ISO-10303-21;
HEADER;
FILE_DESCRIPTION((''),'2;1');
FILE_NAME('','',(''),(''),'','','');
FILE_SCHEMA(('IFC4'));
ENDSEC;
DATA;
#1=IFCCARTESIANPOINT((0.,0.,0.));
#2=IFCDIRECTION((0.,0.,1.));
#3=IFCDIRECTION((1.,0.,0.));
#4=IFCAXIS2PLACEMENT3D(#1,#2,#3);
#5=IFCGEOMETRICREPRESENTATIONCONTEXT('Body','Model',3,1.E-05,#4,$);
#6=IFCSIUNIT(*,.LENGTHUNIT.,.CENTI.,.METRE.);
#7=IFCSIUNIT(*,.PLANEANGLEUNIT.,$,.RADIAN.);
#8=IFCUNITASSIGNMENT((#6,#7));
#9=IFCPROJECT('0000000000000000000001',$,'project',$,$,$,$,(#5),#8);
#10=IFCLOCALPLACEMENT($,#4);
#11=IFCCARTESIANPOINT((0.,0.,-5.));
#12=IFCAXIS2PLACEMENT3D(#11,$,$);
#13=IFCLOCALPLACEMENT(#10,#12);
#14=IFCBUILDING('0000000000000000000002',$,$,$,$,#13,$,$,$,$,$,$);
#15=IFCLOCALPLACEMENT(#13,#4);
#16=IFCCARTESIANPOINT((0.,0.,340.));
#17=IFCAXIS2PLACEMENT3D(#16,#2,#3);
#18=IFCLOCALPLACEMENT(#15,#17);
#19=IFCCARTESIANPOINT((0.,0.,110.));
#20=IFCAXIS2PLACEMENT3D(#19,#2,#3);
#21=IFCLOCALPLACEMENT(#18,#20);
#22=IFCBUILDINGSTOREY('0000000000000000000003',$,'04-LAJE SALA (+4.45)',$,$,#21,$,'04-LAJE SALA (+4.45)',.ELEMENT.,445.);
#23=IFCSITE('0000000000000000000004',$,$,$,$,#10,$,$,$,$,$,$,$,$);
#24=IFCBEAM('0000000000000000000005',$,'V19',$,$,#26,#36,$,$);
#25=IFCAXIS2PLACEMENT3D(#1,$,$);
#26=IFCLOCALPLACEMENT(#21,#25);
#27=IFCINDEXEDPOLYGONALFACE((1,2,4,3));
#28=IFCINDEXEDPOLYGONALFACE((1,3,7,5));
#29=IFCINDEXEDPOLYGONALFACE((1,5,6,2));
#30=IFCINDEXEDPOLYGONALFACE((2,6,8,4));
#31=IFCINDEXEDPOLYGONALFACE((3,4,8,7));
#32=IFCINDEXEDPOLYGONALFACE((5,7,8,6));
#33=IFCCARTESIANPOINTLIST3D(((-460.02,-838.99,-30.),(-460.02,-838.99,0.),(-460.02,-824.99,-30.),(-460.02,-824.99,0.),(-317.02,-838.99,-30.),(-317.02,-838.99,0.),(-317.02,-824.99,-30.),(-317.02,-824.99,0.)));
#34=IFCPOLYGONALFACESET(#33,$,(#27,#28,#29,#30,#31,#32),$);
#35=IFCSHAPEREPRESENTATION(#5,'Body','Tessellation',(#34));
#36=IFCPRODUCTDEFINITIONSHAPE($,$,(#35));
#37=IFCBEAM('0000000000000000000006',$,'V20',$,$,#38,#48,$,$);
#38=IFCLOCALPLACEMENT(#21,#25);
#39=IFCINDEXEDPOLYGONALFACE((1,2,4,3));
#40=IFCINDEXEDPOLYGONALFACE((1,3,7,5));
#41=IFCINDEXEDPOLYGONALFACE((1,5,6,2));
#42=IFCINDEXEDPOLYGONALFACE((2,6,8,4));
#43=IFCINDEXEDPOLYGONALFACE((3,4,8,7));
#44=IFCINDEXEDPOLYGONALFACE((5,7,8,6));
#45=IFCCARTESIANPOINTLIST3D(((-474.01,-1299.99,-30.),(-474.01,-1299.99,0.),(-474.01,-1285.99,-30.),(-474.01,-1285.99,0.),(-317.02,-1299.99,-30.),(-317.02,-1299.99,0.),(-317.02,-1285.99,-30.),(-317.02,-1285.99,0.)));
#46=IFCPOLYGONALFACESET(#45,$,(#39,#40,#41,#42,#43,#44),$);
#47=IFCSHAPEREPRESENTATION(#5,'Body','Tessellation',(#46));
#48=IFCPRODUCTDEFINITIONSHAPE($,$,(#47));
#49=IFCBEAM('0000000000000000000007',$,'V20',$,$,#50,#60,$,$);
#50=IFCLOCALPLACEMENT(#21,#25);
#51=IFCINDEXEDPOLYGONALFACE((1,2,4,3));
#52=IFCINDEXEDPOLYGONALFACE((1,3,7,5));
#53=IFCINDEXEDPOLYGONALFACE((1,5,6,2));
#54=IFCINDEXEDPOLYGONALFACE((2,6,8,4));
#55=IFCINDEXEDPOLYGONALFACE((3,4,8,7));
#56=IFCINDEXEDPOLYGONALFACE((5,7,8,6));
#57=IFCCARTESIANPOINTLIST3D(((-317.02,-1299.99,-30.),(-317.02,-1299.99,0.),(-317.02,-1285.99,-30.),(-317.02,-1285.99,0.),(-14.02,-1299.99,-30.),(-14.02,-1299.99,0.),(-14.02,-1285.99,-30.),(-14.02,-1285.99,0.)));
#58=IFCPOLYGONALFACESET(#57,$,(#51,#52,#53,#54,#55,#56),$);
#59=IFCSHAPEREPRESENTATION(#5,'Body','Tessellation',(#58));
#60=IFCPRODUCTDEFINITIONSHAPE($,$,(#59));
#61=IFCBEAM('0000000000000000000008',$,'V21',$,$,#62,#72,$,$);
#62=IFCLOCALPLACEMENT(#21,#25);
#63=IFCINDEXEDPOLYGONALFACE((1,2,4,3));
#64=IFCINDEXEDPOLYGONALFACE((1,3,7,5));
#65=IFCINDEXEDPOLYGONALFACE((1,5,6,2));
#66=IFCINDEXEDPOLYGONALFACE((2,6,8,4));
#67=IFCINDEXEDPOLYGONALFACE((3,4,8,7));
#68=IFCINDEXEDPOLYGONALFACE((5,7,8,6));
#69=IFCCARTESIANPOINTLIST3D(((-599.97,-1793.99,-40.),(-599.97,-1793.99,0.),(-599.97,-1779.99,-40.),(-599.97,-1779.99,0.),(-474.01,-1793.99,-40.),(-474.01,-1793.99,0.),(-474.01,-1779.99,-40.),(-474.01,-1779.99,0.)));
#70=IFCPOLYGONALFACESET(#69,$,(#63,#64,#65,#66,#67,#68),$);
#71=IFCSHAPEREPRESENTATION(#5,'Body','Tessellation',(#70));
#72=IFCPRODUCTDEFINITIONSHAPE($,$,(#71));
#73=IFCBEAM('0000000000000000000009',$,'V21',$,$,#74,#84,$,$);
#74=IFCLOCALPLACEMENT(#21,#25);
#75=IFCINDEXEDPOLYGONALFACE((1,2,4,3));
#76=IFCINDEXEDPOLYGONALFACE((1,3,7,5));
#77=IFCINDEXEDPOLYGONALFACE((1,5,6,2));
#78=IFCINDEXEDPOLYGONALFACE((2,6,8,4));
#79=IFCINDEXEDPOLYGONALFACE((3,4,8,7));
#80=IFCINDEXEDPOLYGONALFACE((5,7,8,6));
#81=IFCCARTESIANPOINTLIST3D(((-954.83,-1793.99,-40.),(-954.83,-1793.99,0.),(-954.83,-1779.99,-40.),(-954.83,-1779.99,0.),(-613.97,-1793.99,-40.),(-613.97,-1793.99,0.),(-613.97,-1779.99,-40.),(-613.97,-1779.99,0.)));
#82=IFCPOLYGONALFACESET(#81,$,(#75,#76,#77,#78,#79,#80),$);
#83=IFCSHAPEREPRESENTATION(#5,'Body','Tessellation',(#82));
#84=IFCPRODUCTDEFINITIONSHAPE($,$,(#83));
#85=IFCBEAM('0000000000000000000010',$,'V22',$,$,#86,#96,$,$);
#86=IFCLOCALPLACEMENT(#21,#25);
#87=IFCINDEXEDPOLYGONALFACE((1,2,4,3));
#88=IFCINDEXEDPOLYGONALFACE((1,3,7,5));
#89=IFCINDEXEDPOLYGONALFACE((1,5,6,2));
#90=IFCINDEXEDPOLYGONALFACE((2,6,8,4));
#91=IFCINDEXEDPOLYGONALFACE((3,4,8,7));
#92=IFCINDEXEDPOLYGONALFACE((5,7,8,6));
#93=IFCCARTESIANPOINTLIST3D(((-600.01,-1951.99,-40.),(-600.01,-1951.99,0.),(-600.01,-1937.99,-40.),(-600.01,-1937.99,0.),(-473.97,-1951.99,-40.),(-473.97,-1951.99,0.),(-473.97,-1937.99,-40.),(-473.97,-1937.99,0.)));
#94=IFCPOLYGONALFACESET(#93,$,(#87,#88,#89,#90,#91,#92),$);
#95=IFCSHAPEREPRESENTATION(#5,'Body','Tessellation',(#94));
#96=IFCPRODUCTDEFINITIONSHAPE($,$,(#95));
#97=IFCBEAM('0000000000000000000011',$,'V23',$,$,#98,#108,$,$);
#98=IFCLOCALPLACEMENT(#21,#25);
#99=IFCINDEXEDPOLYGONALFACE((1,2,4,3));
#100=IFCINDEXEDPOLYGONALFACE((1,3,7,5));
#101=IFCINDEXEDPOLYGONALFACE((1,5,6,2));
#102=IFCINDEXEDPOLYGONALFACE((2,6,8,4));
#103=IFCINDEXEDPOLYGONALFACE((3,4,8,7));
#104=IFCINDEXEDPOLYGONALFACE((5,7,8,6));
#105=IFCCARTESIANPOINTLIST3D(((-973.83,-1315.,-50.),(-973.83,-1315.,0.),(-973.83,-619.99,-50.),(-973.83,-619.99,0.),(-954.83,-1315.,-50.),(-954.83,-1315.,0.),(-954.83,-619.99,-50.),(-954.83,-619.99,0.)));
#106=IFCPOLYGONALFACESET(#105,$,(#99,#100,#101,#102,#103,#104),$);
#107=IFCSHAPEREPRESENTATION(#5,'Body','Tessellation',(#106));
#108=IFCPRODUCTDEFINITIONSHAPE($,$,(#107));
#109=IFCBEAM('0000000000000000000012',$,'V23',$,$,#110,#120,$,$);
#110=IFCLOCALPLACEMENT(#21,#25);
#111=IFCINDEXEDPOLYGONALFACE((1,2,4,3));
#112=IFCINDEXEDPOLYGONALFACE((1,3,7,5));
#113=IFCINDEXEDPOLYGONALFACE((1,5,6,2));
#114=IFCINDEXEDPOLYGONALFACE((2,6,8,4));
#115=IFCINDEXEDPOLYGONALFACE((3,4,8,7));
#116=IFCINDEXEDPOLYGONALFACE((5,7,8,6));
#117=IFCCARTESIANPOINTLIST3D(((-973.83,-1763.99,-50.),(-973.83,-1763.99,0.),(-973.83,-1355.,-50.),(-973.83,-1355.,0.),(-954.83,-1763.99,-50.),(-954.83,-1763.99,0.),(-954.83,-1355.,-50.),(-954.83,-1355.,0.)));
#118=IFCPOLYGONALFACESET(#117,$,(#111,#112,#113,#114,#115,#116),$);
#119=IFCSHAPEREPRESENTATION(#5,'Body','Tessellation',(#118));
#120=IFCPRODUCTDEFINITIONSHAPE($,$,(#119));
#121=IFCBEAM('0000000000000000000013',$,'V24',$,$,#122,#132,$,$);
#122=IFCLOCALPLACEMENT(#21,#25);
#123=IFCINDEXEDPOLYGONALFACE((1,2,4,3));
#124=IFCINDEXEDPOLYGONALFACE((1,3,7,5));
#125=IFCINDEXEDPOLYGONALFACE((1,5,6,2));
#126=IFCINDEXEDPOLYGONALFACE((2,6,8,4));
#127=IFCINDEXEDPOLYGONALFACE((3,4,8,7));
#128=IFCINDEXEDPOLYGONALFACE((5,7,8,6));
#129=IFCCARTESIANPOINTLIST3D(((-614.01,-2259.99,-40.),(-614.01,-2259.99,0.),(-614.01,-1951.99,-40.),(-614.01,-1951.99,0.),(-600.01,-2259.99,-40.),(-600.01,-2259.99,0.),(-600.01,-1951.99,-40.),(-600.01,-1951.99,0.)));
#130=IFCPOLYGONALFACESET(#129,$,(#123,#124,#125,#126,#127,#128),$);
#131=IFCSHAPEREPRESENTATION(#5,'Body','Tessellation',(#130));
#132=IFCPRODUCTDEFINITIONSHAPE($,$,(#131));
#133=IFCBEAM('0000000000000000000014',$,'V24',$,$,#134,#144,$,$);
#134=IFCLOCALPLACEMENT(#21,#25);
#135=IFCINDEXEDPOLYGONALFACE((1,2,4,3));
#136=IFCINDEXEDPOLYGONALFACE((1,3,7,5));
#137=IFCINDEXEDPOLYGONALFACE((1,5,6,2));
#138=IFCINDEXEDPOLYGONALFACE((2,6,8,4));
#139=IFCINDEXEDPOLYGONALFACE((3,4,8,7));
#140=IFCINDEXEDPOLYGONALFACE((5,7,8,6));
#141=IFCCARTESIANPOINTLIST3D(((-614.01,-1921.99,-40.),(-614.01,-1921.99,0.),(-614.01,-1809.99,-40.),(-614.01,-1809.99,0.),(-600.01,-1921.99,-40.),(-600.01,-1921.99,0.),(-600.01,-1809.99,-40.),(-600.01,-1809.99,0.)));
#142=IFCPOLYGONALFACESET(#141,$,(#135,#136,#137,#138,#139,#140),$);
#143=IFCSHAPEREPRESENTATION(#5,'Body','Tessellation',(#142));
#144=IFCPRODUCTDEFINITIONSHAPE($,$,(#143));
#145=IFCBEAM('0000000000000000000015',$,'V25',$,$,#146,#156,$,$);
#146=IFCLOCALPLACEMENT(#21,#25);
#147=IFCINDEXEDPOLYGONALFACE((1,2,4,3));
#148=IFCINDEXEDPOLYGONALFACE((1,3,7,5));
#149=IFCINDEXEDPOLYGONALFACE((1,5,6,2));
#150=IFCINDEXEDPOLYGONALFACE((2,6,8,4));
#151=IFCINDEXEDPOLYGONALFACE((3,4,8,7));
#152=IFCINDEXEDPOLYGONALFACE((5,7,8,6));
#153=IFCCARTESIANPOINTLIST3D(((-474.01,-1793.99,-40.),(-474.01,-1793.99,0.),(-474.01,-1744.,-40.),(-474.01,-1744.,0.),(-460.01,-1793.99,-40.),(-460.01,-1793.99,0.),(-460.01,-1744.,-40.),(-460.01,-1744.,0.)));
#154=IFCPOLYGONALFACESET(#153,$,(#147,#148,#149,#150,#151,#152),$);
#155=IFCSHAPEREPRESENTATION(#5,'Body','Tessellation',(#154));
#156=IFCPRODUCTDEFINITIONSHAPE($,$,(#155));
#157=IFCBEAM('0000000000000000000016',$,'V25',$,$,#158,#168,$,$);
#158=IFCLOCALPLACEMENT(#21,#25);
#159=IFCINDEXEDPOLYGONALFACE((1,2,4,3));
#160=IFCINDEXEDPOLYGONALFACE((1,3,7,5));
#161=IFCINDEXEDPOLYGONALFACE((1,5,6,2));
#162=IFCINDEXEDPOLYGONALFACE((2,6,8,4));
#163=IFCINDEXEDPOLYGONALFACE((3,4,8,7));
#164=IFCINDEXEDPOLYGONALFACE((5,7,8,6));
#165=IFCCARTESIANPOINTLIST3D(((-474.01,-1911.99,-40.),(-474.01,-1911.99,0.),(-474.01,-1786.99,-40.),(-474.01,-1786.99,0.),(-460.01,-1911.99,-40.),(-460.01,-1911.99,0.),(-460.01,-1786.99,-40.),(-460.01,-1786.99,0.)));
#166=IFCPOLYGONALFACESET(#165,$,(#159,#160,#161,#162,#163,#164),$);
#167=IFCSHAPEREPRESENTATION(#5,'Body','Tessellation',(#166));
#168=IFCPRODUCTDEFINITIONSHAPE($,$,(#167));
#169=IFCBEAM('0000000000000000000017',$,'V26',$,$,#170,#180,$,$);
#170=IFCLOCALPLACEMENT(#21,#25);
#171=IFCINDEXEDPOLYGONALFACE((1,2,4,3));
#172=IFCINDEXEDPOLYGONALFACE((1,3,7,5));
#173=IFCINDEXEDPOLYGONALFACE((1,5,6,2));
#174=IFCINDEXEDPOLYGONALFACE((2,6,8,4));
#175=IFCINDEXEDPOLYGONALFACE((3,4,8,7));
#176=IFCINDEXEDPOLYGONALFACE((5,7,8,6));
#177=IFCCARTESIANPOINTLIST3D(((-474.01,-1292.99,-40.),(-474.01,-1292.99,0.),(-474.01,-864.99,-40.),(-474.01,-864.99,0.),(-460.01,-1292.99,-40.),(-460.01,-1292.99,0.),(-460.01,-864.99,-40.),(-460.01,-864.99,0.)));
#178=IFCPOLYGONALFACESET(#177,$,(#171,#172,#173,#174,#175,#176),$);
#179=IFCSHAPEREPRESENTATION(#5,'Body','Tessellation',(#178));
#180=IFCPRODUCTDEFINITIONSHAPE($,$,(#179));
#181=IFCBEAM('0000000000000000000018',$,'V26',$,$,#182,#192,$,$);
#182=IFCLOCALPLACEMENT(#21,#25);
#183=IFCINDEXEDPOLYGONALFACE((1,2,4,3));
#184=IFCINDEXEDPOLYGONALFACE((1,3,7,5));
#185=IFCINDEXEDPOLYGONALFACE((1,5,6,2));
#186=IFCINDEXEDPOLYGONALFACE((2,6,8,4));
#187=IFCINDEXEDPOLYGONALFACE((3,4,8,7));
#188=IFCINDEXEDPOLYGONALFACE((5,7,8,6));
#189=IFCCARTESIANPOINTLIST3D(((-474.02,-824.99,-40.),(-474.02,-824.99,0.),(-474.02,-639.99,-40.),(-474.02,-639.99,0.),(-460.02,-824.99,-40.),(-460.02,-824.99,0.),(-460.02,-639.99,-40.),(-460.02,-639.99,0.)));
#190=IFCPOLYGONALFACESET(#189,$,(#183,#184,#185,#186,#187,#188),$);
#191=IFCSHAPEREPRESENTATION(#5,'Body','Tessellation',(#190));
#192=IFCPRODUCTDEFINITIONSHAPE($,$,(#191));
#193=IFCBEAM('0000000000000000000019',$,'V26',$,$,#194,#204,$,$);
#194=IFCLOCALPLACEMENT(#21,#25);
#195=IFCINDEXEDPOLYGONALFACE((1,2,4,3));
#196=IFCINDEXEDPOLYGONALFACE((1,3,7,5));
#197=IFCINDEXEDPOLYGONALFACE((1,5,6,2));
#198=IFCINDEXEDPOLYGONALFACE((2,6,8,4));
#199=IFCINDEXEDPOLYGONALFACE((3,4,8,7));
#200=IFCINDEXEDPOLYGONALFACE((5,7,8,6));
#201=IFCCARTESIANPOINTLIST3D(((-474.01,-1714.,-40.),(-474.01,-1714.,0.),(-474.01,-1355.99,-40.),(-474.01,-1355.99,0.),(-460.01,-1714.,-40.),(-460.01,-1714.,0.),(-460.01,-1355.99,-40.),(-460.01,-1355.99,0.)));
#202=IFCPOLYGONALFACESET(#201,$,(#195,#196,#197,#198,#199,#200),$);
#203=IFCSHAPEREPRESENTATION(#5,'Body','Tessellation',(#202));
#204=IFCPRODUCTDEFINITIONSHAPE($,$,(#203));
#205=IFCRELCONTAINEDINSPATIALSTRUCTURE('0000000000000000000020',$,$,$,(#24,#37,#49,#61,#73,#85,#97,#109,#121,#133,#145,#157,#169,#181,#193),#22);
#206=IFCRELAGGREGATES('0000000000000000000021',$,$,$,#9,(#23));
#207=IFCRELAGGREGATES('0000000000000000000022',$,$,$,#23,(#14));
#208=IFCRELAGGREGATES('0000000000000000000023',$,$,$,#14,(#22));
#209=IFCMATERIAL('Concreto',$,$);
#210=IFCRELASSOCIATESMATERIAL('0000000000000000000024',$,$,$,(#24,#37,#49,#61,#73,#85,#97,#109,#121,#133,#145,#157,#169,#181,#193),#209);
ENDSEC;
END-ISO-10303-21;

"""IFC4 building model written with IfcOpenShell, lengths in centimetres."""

from ifc_helpers import new_model, si_unit, frame, origin_with_axes, origin_2d_with_axis, place, context, project, spatial, rectangle, extrude, material, element, save


model = new_model("IFC4")

# Units and contexts
model_context = context("Model", 3, precision=1e-05, world=origin_with_axes(), identifier="Body")
ifc_project = project(units=[si_unit("LENGTHUNIT", "METRE", prefix="CENTI"), si_unit("PLANEANGLEUNIT", "RADIAN")], contexts=[model_context])

# Site, building, storey
site_placement = place(None, origin_with_axes())
site = spatial("IfcSite", under=ifc_project, at=site_placement)
building_placement = place(site_placement, frame((0.0, 0.0, -5.0)))
building = spatial("IfcBuilding", under=site, at=building_placement)
placement_1 = place(building_placement, origin_with_axes())
placement_2 = place(placement_1, frame((0.0, 0.0, 340.0), z_axis=(0.0, 0.0, 1.0), x_axis=(1.0, 0.0, 0.0)))
storey_placement = place(placement_2, frame((0.0, 0.0, 110.0), z_axis=(0.0, 0.0, 1.0), x_axis=(1.0, 0.0, 0.0)))
storey = spatial("IfcBuildingStorey", under=building, at=storey_placement, Name="04-LAJE SALA (+4.45)", LongName="04-LAJE SALA (+4.45)", CompositionType="ELEMENT", Elevation=445.0)

# Shared definitions
ifc_material_1 = material(Name="Concreto")

# Beams
beam_1_placement = place(storey_placement, frame((-388.52, -831.99, 0.0), z_axis=(0.0, 0.0, 1.0), x_axis=(1.0, 0.0, 0.0)))
element("IfcBeam", 1, at=beam_1_placement, inside=storey, material=ifc_material_1, Name="V19", context=model_context, shape_type="SolidModel", body=[
    extrude(rectangle(XDim=14.0, YDim=30.0, at=origin_2d_with_axis()), frame((-71.5, 0.0, -15.0), z_axis=(1.0, 0.0, 0.0), x_axis=(0.0, -1.0, 0.0)), (0.0, 0.0, 1.0), 143.0),
])
beam_2_placement = place(storey_placement, frame((-395.51, -1292.99, 0.0), z_axis=(0.0, 0.0, 1.0), x_axis=(1.0, 0.0, 0.0)))
element("IfcBeam", 2, at=beam_2_placement, inside=storey, material=ifc_material_1, Name="V20", context=model_context, shape_type="SolidModel", body=[
    extrude(rectangle(XDim=14.0, YDim=30.0, at=origin_2d_with_axis()), frame((-78.5, 0.0, -15.0), z_axis=(1.0, 0.0, 0.0), x_axis=(0.0, -1.0, 0.0)), (0.0, 0.0, 1.0), 156.99),
])
beam_3_placement = place(storey_placement, frame((-165.52, -1292.99, 0.0), z_axis=(0.0, 0.0, 1.0), x_axis=(1.0, 0.0, 0.0)))
element("IfcBeam", 3, at=beam_3_placement, inside=storey, material=ifc_material_1, Name="V20", context=model_context, shape_type="SolidModel", body=[
    extrude(rectangle(XDim=14.0, YDim=30.0, at=origin_2d_with_axis()), frame((-151.5, 0.0, -15.0), z_axis=(1.0, 0.0, 0.0), x_axis=(0.0, -1.0, 0.0)), (0.0, 0.0, 1.0), 303.0),
])
beam_4_placement = place(storey_placement, frame((-536.99, -1786.99, 0.0), z_axis=(0.0, 0.0, 1.0), x_axis=(1.0, 0.0, 0.0)))
element("IfcBeam", 4, at=beam_4_placement, inside=storey, material=ifc_material_1, Name="V21", context=model_context, shape_type="SolidModel", body=[
    extrude(rectangle(XDim=14.0, YDim=40.0, at=origin_2d_with_axis()), frame((-62.98, 0.0, -20.0), z_axis=(1.0, 0.0, 0.0), x_axis=(0.0, -1.0, 0.0)), (0.0, 0.0, 1.0), 125.96),
])
beam_5_placement = place(storey_placement, frame((-784.4, -1786.99, 0.0), z_axis=(0.0, 0.0, 1.0), x_axis=(1.0, 0.0, 0.0)))
element("IfcBeam", 5, at=beam_5_placement, inside=storey, material=ifc_material_1, Name="V21", context=model_context, shape_type="SolidModel", body=[
    extrude(rectangle(XDim=14.0, YDim=40.0, at=origin_2d_with_axis()), frame((-170.43, 0.0, -20.0), z_axis=(1.0, 0.0, 0.0), x_axis=(0.0, -1.0, 0.0)), (0.0, 0.0, 1.0), 340.86),
])
beam_6_placement = place(storey_placement, frame((-536.99, -1944.99, 0.0), z_axis=(0.0, 0.0, 1.0), x_axis=(1.0, 0.0, 0.0)))
element("IfcBeam", 6, at=beam_6_placement, inside=storey, material=ifc_material_1, Name="V22", context=model_context, shape_type="SolidModel", body=[
    extrude(rectangle(XDim=14.0, YDim=40.0, at=origin_2d_with_axis()), frame((-63.02, 0.0, -20.0), z_axis=(1.0, 0.0, 0.0), x_axis=(0.0, -1.0, 0.0)), (0.0, 0.0, 1.0), 126.04),
])
beam_7_placement = place(storey_placement, frame((-964.33, -967.5, 0.0), z_axis=(0.0, 0.0, 1.0), x_axis=(1.0, 0.0, 0.0)))
element("IfcBeam", 7, at=beam_7_placement, inside=storey, material=ifc_material_1, Name="V23", context=model_context, shape_type="SolidModel", body=[
    extrude(rectangle(XDim=19.0, YDim=50.0, at=origin_2d_with_axis()), frame((0.0, -347.5, -25.0), z_axis=(0.0, 1.0, 0.0), x_axis=(-1.0, 0.0, 0.0)), (0.0, 0.0, 1.0), 695.01),
])
beam_8_placement = place(storey_placement, frame((-964.33, -1559.49, 0.0), z_axis=(0.0, 0.0, 1.0), x_axis=(1.0, 0.0, 0.0)))
element("IfcBeam", 8, at=beam_8_placement, inside=storey, material=ifc_material_1, Name="V23", context=model_context, shape_type="SolidModel", body=[
    extrude(rectangle(XDim=19.0, YDim=50.0, at=origin_2d_with_axis()), frame((0.0, -204.5, -25.0), z_axis=(0.0, 1.0, 0.0), x_axis=(1.0, 0.0, 0.0)), (0.0, 0.0, 1.0), 408.99),
])
beam_9_placement = place(storey_placement, frame((-607.01, -2105.99, 0.0), z_axis=(0.0, 0.0, 1.0), x_axis=(1.0, 0.0, 0.0)))
element("IfcBeam", 9, at=beam_9_placement, inside=storey, material=ifc_material_1, Name="V24", context=model_context, shape_type="SolidModel", body=[
    extrude(rectangle(XDim=14.0, YDim=40.0, at=origin_2d_with_axis()), frame((0.0, -154.0, -20.0), z_axis=(0.0, 1.0, 0.0), x_axis=(1.0, 0.0, 0.0)), (0.0, 0.0, 1.0), 308.0),
])
beam_10_placement = place(storey_placement, frame((-607.01, -1865.99, 0.0), z_axis=(0.0, 0.0, 1.0), x_axis=(1.0, 0.0, 0.0)))
element("IfcBeam", 10, at=beam_10_placement, inside=storey, material=ifc_material_1, Name="V24", context=model_context, shape_type="SolidModel", body=[
    extrude(rectangle(XDim=14.0, YDim=40.0, at=origin_2d_with_axis()), frame((0.0, -56.0, -20.0), z_axis=(0.0, 1.0, 0.0), x_axis=(1.0, 0.0, 0.0)), (0.0, 0.0, 1.0), 112.0),
])
beam_11_placement = place(storey_placement, frame((-467.01, -1768.99, 0.0), z_axis=(0.0, 0.0, 1.0), x_axis=(1.0, 0.0, 0.0)))
element("IfcBeam", 11, at=beam_11_placement, inside=storey, material=ifc_material_1, Name="V25", context=model_context, shape_type="SolidModel", body=[
    extrude(rectangle(XDim=14.0, YDim=40.0, at=origin_2d_with_axis()), frame((0.0, -25.0, -20.0), z_axis=(0.0, 1.0, 0.0), x_axis=(1.0, 0.0, 0.0)), (0.0, 0.0, 1.0), 49.99),
])
beam_12_placement = place(storey_placement, frame((-467.01, -1849.49, 0.0), z_axis=(0.0, 0.0, 1.0), x_axis=(1.0, 0.0, 0.0)))
element("IfcBeam", 12, at=beam_12_placement, inside=storey, material=ifc_material_1, Name="V25", context=model_context, shape_type="SolidModel", body=[
    extrude(rectangle(XDim=14.0, YDim=40.0, at=origin_2d_with_axis()), frame((0.0, -62.5, -20.0), z_axis=(0.0, 1.0, 0.0), x_axis=(1.0, 0.0, 0.0)), (0.0, 0.0, 1.0), 125.0),
])
beam_13_placement = place(storey_placement, frame((-467.01, -1078.99, 0.0), z_axis=(0.0, 0.0, 1.0), x_axis=(1.0, 0.0, 0.0)))
element("IfcBeam", 13, at=beam_13_placement, inside=storey, material=ifc_material_1, Name="V26", context=model_context, shape_type="SolidModel", body=[
    extrude(rectangle(XDim=14.0, YDim=40.0, at=origin_2d_with_axis()), frame((0.0, -214.0, -20.0), z_axis=(0.0, 1.0, 0.0), x_axis=(1.0, 0.0, 0.0)), (0.0, 0.0, 1.0), 428.0),
])
beam_14_placement = place(storey_placement, frame((-467.02, -732.49, 0.0), z_axis=(0.0, 0.0, 1.0), x_axis=(1.0, 0.0, 0.0)))
element("IfcBeam", 14, at=beam_14_placement, inside=storey, material=ifc_material_1, Name="V26", context=model_context, shape_type="SolidModel", body=[
    extrude(rectangle(XDim=14.0, YDim=40.0, at=origin_2d_with_axis()), frame((0.0, -92.5, -20.0), z_axis=(0.0, 1.0, 0.0), x_axis=(1.0, 0.0, 0.0)), (0.0, 0.0, 1.0), 185.0),
])
beam_15_placement = place(storey_placement, frame((-467.01, -1534.99, 0.0), z_axis=(0.0, 0.0, 1.0), x_axis=(1.0, 0.0, 0.0)))
element("IfcBeam", 15, at=beam_15_placement, inside=storey, material=ifc_material_1, Name="V26", context=model_context, shape_type="SolidModel", body=[
    extrude(rectangle(XDim=14.0, YDim=40.0, at=origin_2d_with_axis()), frame((0.0, -179.0, -20.0), z_axis=(0.0, 1.0, 0.0), x_axis=(1.0, 0.0, 0.0)), (0.0, 0.0, 1.0), 358.01),
])

save(model, "model.ifc")
